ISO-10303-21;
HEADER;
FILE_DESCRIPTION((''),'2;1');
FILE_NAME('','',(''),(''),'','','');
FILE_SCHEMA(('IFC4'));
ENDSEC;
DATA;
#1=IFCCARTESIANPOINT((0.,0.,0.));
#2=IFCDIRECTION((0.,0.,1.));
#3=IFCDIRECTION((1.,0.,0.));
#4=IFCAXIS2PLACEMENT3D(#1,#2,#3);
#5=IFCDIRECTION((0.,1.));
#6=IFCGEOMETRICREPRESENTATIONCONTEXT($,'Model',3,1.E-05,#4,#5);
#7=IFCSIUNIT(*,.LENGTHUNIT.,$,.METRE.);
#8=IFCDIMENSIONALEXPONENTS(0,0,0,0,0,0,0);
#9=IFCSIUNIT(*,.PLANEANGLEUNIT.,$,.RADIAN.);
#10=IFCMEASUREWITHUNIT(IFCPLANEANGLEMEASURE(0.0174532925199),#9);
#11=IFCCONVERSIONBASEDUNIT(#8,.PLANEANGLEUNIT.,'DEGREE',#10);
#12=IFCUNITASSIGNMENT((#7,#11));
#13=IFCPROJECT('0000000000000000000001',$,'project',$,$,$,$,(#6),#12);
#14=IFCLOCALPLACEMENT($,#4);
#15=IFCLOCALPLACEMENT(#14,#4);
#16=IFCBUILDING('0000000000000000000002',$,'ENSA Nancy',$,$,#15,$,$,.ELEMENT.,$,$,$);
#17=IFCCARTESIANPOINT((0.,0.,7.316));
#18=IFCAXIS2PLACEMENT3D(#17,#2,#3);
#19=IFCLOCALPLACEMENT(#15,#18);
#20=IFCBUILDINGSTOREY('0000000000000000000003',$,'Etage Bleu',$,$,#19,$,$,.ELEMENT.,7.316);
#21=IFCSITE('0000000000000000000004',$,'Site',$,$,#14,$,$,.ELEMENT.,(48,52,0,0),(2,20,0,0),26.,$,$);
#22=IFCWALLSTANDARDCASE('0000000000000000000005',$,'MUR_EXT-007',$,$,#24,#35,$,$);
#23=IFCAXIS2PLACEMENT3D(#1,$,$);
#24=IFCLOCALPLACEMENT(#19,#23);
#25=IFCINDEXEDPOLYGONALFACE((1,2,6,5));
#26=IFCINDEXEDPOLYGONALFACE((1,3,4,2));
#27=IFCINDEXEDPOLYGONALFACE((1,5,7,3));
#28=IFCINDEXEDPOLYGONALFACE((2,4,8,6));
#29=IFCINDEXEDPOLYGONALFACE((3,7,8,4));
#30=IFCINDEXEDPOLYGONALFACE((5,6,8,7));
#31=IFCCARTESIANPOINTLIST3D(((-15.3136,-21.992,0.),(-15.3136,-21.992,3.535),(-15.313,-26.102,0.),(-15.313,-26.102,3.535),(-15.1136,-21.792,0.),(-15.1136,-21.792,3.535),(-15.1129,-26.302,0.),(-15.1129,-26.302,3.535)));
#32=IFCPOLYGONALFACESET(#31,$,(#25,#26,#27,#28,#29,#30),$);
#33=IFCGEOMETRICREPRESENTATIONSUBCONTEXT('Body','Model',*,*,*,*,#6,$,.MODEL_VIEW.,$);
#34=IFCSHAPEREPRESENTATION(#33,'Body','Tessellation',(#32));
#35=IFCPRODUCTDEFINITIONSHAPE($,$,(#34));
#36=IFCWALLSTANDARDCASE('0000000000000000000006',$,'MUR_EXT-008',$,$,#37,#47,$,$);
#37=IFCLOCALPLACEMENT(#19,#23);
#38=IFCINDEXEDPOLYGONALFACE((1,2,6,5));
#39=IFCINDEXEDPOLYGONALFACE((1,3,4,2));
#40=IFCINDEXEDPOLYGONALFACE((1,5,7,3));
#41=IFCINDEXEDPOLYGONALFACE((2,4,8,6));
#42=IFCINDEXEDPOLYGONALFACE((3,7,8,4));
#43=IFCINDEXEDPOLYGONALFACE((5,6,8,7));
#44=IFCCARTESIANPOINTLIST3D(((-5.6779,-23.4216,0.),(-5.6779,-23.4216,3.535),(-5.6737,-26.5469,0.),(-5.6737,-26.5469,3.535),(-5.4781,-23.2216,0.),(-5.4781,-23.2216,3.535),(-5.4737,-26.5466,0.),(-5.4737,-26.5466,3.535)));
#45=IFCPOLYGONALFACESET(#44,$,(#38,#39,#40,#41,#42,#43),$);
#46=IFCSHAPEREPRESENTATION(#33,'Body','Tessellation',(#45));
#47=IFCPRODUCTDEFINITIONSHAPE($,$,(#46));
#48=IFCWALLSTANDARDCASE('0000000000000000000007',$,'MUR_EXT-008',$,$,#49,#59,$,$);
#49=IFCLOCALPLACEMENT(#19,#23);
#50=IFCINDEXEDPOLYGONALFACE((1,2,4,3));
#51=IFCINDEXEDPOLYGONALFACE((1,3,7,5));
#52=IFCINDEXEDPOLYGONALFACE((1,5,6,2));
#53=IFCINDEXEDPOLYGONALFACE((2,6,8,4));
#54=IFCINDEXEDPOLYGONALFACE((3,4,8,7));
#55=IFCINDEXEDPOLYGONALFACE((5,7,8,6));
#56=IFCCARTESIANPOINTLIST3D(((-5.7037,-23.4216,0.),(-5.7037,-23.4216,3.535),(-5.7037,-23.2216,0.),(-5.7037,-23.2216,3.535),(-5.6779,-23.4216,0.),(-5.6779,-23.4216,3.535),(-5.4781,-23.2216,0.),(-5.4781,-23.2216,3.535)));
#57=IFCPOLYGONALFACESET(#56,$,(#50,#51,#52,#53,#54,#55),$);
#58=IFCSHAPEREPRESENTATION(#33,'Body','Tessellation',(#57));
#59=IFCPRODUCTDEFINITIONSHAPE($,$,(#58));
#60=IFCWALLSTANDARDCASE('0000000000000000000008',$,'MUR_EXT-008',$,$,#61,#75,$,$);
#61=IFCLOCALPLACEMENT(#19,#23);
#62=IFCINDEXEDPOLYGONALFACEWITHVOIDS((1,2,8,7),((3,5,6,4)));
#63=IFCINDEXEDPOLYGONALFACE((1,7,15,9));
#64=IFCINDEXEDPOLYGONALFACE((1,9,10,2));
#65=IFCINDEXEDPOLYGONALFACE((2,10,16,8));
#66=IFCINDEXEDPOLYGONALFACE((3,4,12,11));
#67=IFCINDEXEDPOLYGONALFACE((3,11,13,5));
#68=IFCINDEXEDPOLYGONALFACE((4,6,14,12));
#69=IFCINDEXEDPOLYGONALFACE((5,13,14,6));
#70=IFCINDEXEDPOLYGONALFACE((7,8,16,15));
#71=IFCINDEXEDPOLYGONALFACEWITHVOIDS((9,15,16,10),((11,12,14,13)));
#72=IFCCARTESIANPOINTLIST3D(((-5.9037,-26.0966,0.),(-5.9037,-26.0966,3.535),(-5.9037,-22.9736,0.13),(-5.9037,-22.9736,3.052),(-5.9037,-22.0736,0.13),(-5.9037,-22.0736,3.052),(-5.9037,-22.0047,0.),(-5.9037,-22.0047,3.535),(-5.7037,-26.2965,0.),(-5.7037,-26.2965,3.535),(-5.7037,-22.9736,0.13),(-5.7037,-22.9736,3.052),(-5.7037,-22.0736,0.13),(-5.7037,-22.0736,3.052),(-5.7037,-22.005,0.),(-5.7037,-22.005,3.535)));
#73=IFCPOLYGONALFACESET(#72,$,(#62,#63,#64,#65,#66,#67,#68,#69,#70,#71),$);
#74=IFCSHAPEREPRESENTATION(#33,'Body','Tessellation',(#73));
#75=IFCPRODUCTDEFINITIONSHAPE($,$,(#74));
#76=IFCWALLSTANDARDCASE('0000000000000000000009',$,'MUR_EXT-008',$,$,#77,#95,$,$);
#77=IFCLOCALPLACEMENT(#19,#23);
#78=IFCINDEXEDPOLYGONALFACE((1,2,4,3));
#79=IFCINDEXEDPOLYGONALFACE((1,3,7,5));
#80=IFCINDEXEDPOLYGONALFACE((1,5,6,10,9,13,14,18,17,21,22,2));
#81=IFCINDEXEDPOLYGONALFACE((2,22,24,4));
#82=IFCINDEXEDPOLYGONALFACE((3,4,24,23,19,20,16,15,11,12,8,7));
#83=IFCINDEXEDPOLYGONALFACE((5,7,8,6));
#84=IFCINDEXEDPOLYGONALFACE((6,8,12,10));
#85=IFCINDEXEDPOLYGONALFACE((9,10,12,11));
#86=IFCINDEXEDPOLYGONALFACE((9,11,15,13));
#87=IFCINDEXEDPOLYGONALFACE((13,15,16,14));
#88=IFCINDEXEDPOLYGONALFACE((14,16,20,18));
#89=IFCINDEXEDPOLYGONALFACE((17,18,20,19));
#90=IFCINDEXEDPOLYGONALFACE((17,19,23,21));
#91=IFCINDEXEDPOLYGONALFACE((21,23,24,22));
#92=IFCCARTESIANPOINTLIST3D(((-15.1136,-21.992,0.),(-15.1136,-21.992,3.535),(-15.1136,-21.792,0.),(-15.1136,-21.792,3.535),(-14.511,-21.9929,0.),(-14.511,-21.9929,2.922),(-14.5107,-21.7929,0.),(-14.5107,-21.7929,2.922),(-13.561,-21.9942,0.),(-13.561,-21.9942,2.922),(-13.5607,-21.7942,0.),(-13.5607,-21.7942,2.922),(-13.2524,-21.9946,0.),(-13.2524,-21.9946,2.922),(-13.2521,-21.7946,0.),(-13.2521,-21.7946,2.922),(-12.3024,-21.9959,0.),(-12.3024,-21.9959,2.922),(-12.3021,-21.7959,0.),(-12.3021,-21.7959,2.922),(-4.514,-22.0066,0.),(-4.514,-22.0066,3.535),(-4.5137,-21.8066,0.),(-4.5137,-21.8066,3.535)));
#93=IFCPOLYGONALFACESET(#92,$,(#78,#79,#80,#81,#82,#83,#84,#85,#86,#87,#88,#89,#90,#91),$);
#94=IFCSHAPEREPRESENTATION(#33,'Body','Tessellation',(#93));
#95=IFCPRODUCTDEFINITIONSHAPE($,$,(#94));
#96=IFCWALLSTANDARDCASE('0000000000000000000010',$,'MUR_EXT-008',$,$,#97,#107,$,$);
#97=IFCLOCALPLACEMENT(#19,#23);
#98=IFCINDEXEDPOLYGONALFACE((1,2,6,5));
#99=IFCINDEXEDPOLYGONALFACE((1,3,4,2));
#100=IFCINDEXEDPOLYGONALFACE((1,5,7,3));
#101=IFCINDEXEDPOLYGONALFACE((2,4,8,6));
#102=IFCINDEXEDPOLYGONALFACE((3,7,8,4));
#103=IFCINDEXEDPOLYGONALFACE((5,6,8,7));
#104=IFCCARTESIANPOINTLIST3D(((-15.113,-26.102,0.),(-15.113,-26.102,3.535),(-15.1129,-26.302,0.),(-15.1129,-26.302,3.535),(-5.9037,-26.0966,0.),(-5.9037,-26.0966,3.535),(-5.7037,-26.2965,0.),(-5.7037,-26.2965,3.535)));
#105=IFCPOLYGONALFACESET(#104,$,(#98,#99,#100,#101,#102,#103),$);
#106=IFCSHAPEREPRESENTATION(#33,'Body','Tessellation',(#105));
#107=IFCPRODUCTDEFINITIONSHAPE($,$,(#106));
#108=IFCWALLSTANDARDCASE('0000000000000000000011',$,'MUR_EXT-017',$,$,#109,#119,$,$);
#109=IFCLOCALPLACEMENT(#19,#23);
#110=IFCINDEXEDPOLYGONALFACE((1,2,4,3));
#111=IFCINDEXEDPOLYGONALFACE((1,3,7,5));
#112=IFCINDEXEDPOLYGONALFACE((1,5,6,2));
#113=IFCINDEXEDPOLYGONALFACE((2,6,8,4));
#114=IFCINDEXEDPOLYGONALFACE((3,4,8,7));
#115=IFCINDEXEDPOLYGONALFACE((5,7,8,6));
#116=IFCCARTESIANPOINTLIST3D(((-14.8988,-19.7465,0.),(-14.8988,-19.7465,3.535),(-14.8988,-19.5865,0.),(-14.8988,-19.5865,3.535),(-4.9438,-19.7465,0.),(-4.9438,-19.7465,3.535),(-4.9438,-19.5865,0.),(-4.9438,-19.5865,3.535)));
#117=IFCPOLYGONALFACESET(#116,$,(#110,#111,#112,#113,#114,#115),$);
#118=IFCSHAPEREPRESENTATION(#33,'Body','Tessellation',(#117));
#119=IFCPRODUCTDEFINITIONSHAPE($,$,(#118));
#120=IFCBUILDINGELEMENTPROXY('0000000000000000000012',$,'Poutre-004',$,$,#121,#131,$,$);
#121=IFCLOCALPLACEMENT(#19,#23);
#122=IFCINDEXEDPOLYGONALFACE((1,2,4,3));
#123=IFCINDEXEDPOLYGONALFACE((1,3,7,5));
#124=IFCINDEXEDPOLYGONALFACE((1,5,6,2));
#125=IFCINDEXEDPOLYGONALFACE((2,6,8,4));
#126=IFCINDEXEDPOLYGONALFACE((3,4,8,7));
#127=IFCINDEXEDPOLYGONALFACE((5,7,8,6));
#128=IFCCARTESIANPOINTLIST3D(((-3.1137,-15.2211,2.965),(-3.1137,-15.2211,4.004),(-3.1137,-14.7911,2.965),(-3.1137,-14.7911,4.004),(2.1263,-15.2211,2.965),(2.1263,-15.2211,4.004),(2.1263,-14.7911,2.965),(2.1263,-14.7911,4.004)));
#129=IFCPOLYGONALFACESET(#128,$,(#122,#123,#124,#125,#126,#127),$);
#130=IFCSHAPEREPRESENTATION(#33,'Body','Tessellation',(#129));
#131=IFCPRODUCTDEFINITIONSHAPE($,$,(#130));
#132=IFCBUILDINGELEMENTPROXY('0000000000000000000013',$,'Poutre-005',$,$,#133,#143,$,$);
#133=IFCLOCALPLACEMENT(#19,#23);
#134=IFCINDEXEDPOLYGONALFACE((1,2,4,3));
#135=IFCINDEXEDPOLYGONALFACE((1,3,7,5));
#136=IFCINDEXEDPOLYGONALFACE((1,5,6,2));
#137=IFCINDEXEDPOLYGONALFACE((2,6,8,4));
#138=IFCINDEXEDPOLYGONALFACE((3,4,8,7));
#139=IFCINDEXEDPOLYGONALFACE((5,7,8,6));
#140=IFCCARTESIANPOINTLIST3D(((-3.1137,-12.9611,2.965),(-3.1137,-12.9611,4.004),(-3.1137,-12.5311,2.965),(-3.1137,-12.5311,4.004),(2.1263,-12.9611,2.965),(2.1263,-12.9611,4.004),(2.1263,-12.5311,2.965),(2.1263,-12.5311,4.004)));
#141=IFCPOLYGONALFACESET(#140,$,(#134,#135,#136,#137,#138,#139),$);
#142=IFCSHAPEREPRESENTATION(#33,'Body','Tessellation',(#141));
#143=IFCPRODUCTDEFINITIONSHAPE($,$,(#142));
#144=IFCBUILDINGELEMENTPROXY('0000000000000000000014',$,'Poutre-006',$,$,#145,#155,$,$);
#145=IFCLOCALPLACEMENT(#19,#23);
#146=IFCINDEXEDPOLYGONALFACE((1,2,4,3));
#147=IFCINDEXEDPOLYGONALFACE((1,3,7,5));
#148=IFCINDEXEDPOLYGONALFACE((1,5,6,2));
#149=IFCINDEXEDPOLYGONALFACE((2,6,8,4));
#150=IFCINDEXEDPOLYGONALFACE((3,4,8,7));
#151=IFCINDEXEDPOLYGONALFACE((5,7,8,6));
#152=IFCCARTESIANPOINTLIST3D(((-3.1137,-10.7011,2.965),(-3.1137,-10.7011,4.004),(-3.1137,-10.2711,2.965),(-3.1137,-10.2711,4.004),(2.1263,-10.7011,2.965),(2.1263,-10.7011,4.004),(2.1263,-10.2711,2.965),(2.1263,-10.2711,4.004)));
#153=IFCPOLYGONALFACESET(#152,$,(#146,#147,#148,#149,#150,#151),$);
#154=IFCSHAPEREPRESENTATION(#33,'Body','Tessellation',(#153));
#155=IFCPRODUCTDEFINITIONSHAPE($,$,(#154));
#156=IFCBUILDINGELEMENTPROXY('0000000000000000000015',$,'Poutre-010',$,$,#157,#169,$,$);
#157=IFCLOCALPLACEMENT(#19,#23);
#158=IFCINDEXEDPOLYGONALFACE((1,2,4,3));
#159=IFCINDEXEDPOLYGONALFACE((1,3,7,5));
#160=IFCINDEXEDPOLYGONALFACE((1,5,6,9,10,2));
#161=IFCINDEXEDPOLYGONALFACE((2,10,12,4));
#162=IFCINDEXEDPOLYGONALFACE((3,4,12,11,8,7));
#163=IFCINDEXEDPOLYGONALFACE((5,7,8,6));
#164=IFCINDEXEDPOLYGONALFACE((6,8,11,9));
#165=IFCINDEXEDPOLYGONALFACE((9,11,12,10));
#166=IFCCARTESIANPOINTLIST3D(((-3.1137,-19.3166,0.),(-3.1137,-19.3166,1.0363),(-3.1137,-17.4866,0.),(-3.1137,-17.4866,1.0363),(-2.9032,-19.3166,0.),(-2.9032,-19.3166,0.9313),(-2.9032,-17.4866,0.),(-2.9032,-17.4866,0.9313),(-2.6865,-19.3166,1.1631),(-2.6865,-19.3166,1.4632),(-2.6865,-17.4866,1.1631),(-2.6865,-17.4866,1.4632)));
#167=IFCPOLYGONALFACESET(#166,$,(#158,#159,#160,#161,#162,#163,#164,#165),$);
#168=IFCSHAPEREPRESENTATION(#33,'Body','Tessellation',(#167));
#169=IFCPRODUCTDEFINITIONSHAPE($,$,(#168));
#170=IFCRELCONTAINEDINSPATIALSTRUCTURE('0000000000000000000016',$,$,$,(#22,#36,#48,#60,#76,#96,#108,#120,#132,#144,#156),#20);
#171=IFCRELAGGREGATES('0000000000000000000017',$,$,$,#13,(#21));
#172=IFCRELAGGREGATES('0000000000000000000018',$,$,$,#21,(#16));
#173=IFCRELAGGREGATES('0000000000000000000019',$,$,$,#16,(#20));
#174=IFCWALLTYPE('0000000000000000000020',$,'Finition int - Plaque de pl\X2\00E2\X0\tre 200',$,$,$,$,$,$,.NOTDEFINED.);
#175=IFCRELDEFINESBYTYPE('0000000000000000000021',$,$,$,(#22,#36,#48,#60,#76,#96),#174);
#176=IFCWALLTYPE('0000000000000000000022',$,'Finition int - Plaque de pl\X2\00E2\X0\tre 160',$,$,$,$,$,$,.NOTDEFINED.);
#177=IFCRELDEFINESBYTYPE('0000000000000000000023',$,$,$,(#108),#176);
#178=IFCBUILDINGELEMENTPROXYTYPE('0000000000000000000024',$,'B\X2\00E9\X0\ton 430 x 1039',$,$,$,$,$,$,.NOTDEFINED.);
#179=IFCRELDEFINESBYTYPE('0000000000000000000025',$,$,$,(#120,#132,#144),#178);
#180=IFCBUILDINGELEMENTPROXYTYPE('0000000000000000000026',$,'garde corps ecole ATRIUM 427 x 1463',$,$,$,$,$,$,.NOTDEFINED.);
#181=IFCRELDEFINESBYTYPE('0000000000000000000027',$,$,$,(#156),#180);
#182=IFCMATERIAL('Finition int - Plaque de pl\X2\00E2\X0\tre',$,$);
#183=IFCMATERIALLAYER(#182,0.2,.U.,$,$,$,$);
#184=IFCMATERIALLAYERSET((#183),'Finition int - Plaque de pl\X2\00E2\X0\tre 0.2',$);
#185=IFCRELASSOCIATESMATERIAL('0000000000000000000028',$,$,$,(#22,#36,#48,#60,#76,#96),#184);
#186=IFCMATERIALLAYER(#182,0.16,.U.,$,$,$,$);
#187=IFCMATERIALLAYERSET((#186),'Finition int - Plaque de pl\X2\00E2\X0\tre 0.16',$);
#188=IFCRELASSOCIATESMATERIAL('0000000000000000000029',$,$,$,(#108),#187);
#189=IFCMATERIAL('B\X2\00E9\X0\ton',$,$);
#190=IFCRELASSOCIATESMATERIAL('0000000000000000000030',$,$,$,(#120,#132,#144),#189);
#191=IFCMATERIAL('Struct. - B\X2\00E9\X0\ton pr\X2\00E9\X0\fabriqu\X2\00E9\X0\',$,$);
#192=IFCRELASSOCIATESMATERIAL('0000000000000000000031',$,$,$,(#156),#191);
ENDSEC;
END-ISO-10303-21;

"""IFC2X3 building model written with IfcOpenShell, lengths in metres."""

from ifc_helpers import new_model, entity, si_unit, converted_unit, direction, frame, frame_2d, origin_with_axes, origin_2d_with_axis, place, context, subcontext, project, spatial, polyline, rectangle, outline, extrude, material, layer, layer_set, layer_usage, type_object, element, save


model = new_model("IFC2X3")

# Units and contexts
model_context = context("Model", 3, precision=1e-05, world=origin_with_axes(), true_north=direction((0.0, 1.0)))
body_context = subcontext(model_context, "Body", "Model", "MODEL_VIEW")
ifc_project = project(units=[si_unit("LENGTHUNIT", "METRE"), converted_unit("PLANEANGLEUNIT", "DEGREE", entity("IfcPlaneAngleMeasure", 0.0174532925199), si_unit("PLANEANGLEUNIT", "RADIAN"), dimensions=[0, 0, 0, 0, 0, 0, 0])], contexts=[model_context])

# Site, building, storey
site_placement = place(None, origin_with_axes())
site = spatial("IfcSite", under=ifc_project, at=site_placement, Name="Site", CompositionType="ELEMENT", RefLatitude=(48, 52, 0, 0), RefLongitude=(2, 20, 0, 0), RefElevation=26.0)
building_placement = place(site_placement, origin_with_axes())
building = spatial("IfcBuilding", under=site, at=building_placement, Name="ENSA Nancy", CompositionType="ELEMENT")
storey_placement = place(building_placement, frame((0.0, 0.0, 7.316), z_axis=(0.0, 0.0, 1.0), x_axis=(1.0, 0.0, 0.0)))
storey = spatial("IfcBuildingStorey", under=building, at=storey_placement, Name="Etage Bleu", CompositionType="ELEMENT", Elevation=7.316)

# Walls
ifc_material_1 = material(Name="Finition int - Plaque de plâtre")
ifc_layer_1 = layer(ifc_material_1, 0.2, ventilated="UNKNOWN")
ifc_layer_set_1 = layer_set([ifc_layer_1], Name="Finition int - Plaque de plâtre 0.2")
ifc_layer_usage_1 = layer_usage(ifc_layer_set_1, "AXIS2", "POSITIVE", 0.0)
wall_type_1 = type_object("IfcWallType", Name="Finition int - Plaque de plâtre 200", PredefinedType="NOTDEFINED")
wall_1_placement = place(storey_placement, frame((-15.1129, -26.302, 0.0), z_axis=(0.0, 0.0, 1.0), x_axis=(-0.00015, 1.0, 0.0)))
element("IfcWallStandardCase", 1, at=wall_1_placement, inside=storey, type_object=wall_type_1, material=ifc_layer_usage_1, Name="MUR_EXT-007", context=body_context, shape_type="SweptSolid", body=[
    extrude(outline(polyline([(0.0, 0.0), (4.51, 0.0), (4.31, 0.2), (0.2, 0.2), (0.0, 0.0)])), origin_with_axes(), (0.0, 0.0, 1.0), 3.535),
])
ifc_layer_usage_2 = layer_usage(ifc_layer_set_1, "AXIS2", "NEGATIVE", 0.0)
wall_2_placement = place(storey_placement, frame((-5.4781, -23.2216, 0.0), z_axis=(0.0, 0.0, 1.0), x_axis=(0.001341, -0.999999, 0.0)))
element("IfcWallStandardCase", 2, at=wall_2_placement, inside=storey, type_object=wall_type_1, material=ifc_layer_usage_2, Name="MUR_EXT-008", context=body_context, shape_type="SweptSolid", body=[
    extrude(outline(polyline([(0.1997, -0.2), (3.325, -0.2), (3.325, 0.0), (0.0, 0.0), (0.1997, -0.2)])), origin_with_axes(), (0.0, 0.0, 1.0), 3.535),
])
ifc_layer_usage_3 = layer_usage(ifc_layer_set_1, "AXIS2", "NEGATIVE", 0.0)
wall_3_placement = place(storey_placement, frame((-5.7037, -23.2216, 0.0), z_axis=(0.0, 0.0, 1.0), x_axis=(1.0, 0.0, 0.0)))
element("IfcWallStandardCase", 3, at=wall_3_placement, inside=storey, type_object=wall_type_1, material=ifc_layer_usage_3, Name="MUR_EXT-008", context=body_context, shape_type="SweptSolid", body=[
    extrude(outline(polyline([(0.0, -0.2), (0.0258, -0.2), (0.2255, 0.0), (0.0, 0.0), (0.0, -0.2)])), origin_with_axes(), (0.0, 0.0, 1.0), 3.535),
])

# Wall, opening
ifc_layer_usage_4 = layer_usage(ifc_layer_set_1, "AXIS2", "NEGATIVE", 0.0)
wall_4_placement = place(storey_placement, frame((-5.7037, -21.805, 0.0), z_axis=(0.0, 0.0, 1.0), x_axis=(0.0, -1.0, 0.0)))
wall_4 = element("IfcWallStandardCase", 4, at=wall_4_placement, inside=storey, type_object=wall_type_1, material=ifc_layer_usage_4, Name="MUR_EXT-008", context=body_context, shape_type="SweptSolid", body=[
    extrude(outline(polyline([(0.1997, -0.2), (4.2917, -0.2), (4.4915, 0.0), (0.2, 0.0), (0.1997, -0.2)])), origin_with_axes(), (0.0, 0.0, 1.0), 3.535),
])
opening_1_placement = place(wall_4_placement, frame((0.7186, 0.0, 0.13), z_axis=(0.0, 0.0, 1.0), x_axis=(1.0, 0.0, 0.0)))
element("IfcOpeningElement", 5, at=opening_1_placement, cuts=wall_4, context=body_context, shape_type="SweptSolid", body=[
    extrude(rectangle(XDim=0.9, YDim=2.922, at=origin_2d_with_axis()), frame((0.0, -0.2, 1.461), z_axis=(0.0, 1.0, 0.0), x_axis=(-1.0, 0.0, 0.0)), (0.0, 0.0, 1.0), 0.6),
])

# Wall, openings
ifc_layer_usage_5 = layer_usage(ifc_layer_set_1, "AXIS2", "POSITIVE", 0.0)
wall_5_placement = place(storey_placement, frame((-4.5137, -21.8066, 0.0), z_axis=(0.0, 0.0, 1.0), x_axis=(-0.999999, 0.001372, 0.0)))
wall_5 = element("IfcWallStandardCase", 6, at=wall_5_placement, inside=storey, type_object=wall_type_1, material=ifc_layer_usage_5, Name="MUR_EXT-008", context=body_context, shape_type="SweptSolid", body=[
    extrude(outline(polyline([(0.0, 0.0), (10.5999, 0.0), (10.5996, 0.2), (0.0, 0.2), (0.0, 0.0)])), origin_with_axes(), (0.0, 0.0, 1.0), 3.535),
])
opening_2_placement = place(wall_5_placement, frame((8.2634, 0.0, 0.0), z_axis=(0.0, 0.0, 1.0), x_axis=(1.0, 0.0, 0.0)))
element("IfcOpeningElement", 7, at=opening_2_placement, cuts=wall_5, context=body_context, shape_type="SweptSolid", body=[
    extrude(rectangle(XDim=0.95, YDim=2.922, at=origin_2d_with_axis()), frame((0.0, 0.2, 1.461), z_axis=(0.0, 1.0, 0.0), x_axis=(1.0, 0.0, 0.0)), (0.0, 0.0, -1.0), 0.6),
])
opening_3_placement = place(wall_5_placement, frame((9.522, 0.0, 0.0), z_axis=(0.0, 0.0, 1.0), x_axis=(1.0, 0.0, 0.0)))
element("IfcOpeningElement", 8, at=opening_3_placement, cuts=wall_5, context=body_context, shape_type="SweptSolid", body=[
    extrude(rectangle(XDim=0.95, YDim=2.922, at=origin_2d_with_axis()), frame((0.0, 0.2, 1.461), z_axis=(0.0, -1.0, 0.0), x_axis=(-1.0, 0.0, 0.0)), (0.0, 0.0, 1.0), 0.6),
])

# Walls
ifc_layer_usage_6 = layer_usage(ifc_layer_set_1, "AXIS2", "NEGATIVE", 0.0)
wall_6_placement = place(storey_placement, frame((-5.7037, -26.2965, 0.0), z_axis=(0.0, 0.0, 1.0), x_axis=(-1.0, -0.000589, 0.0)))
element("IfcWallStandardCase", 9, at=wall_6_placement, inside=storey, type_object=wall_type_1, material=ifc_layer_usage_6, Name="MUR_EXT-008", context=body_context, shape_type="SweptSolid", body=[
    extrude(outline(polyline([(0.1999, -0.2), (9.4092, -0.2), (9.4092, 0.0), (0.0, 0.0), (0.1999, -0.2)])), origin_with_axes(), (0.0, 0.0, 1.0), 3.535),
])
ifc_layer_2 = layer(ifc_material_1, 0.16, ventilated="UNKNOWN")
ifc_layer_set_2 = layer_set([ifc_layer_2], Name="Finition int - Plaque de plâtre 0.16")
ifc_layer_usage_7 = layer_usage(ifc_layer_set_2, "AXIS2", "POSITIVE", -0.16)
wall_type_2 = type_object("IfcWallType", Name="Finition int - Plaque de plâtre 160", PredefinedType="NOTDEFINED")
wall_7_placement = place(storey_placement, frame((-14.8988, -19.5865, 0.0), z_axis=(0.0, 0.0, 1.0), x_axis=(1.0, 0.0, 0.0)))
element("IfcWallStandardCase", 10, at=wall_7_placement, inside=storey, type_object=wall_type_2, material=ifc_layer_usage_7, Name="MUR_EXT-017", context=body_context, shape_type="SweptSolid", body=[
    extrude(outline(polyline([(0.0, -0.16), (9.955, -0.16), (9.955, 0.0), (0.0, 0.0), (0.0, -0.16)])), origin_with_axes(), (0.0, 0.0, 1.0), 3.535),
])

# Building element proxies
ifc_material_2 = material(Name="Béton")
building_element_proxy_type_1 = type_object("IfcBuildingElementProxyType", Name="Béton 430 x 1039", PredefinedType="NOTDEFINED")
for number, where, z_axis, x_axis, name in (
    (11, (-3.1137, -15.0061, 4.004), (0.0, 0.0, 1.0), (0.0, -1.0, 0.0), "Poutre-004"),
    (12, (-3.1137, -12.7461, 4.004), (0.0, 0.0, 1.0), (0.0, -1.0, 0.0), "Poutre-005"),
    (13, (-3.1137, -10.4861, 4.004), (0.0, 0.0, 1.0), (0.0, -1.0, 0.0), "Poutre-006"),
):
    element("IfcBuildingElementProxy", number, at=place(storey_placement, frame(where, z_axis=z_axis, x_axis=x_axis)), inside=storey, type_object=building_element_proxy_type_1, material=ifc_material_2, Name=name, context=body_context, shape_type="SweptSolid", body=[
        extrude(rectangle(XDim=1.039, YDim=0.43, at=frame_2d((-0.5195, 0.0), x_axis=(1.0, 0.0))), frame((0.0, 0.0, 0.0), z_axis=(0.0, 1.0, 0.0), x_axis=(0.0, 0.0, 1.0)), (0.0, 0.0, 1.0), 5.24),
    ])
ifc_material_3 = material(Name="Struct. - Béton préfabriqué")
building_element_proxy_type_2 = type_object("IfcBuildingElementProxyType", Name="garde corps ecole ATRIUM 427 x 1463", PredefinedType="NOTDEFINED")
proxy_1_placement = place(storey_placement, frame((-3.1137, -19.3166, 0.0), z_axis=(0.0, 0.0, 1.0), x_axis=(1.0, 0.0, 0.0)))
element("IfcBuildingElementProxy", 14, at=proxy_1_placement, inside=storey, type_object=building_element_proxy_type_2, material=ifc_material_3, Name="Poutre-010", context=body_context, shape_type="SweptSolid", body=[
    extrude(outline(polyline([(0.0, 1.0363), (0.0, 0.0), (0.2105, 0.0), (0.2105, 0.9313), (0.4272, 1.1631), (0.4272, 1.4632), (0.0, 1.0363)])), frame((0.0, 1.83, 0.0), z_axis=(0.0, -1.0, 0.0), x_axis=(1.0, 0.0, 0.0)), (0.0, 0.0, 1.0), 1.83),
])

save(model, "model.ifc")
